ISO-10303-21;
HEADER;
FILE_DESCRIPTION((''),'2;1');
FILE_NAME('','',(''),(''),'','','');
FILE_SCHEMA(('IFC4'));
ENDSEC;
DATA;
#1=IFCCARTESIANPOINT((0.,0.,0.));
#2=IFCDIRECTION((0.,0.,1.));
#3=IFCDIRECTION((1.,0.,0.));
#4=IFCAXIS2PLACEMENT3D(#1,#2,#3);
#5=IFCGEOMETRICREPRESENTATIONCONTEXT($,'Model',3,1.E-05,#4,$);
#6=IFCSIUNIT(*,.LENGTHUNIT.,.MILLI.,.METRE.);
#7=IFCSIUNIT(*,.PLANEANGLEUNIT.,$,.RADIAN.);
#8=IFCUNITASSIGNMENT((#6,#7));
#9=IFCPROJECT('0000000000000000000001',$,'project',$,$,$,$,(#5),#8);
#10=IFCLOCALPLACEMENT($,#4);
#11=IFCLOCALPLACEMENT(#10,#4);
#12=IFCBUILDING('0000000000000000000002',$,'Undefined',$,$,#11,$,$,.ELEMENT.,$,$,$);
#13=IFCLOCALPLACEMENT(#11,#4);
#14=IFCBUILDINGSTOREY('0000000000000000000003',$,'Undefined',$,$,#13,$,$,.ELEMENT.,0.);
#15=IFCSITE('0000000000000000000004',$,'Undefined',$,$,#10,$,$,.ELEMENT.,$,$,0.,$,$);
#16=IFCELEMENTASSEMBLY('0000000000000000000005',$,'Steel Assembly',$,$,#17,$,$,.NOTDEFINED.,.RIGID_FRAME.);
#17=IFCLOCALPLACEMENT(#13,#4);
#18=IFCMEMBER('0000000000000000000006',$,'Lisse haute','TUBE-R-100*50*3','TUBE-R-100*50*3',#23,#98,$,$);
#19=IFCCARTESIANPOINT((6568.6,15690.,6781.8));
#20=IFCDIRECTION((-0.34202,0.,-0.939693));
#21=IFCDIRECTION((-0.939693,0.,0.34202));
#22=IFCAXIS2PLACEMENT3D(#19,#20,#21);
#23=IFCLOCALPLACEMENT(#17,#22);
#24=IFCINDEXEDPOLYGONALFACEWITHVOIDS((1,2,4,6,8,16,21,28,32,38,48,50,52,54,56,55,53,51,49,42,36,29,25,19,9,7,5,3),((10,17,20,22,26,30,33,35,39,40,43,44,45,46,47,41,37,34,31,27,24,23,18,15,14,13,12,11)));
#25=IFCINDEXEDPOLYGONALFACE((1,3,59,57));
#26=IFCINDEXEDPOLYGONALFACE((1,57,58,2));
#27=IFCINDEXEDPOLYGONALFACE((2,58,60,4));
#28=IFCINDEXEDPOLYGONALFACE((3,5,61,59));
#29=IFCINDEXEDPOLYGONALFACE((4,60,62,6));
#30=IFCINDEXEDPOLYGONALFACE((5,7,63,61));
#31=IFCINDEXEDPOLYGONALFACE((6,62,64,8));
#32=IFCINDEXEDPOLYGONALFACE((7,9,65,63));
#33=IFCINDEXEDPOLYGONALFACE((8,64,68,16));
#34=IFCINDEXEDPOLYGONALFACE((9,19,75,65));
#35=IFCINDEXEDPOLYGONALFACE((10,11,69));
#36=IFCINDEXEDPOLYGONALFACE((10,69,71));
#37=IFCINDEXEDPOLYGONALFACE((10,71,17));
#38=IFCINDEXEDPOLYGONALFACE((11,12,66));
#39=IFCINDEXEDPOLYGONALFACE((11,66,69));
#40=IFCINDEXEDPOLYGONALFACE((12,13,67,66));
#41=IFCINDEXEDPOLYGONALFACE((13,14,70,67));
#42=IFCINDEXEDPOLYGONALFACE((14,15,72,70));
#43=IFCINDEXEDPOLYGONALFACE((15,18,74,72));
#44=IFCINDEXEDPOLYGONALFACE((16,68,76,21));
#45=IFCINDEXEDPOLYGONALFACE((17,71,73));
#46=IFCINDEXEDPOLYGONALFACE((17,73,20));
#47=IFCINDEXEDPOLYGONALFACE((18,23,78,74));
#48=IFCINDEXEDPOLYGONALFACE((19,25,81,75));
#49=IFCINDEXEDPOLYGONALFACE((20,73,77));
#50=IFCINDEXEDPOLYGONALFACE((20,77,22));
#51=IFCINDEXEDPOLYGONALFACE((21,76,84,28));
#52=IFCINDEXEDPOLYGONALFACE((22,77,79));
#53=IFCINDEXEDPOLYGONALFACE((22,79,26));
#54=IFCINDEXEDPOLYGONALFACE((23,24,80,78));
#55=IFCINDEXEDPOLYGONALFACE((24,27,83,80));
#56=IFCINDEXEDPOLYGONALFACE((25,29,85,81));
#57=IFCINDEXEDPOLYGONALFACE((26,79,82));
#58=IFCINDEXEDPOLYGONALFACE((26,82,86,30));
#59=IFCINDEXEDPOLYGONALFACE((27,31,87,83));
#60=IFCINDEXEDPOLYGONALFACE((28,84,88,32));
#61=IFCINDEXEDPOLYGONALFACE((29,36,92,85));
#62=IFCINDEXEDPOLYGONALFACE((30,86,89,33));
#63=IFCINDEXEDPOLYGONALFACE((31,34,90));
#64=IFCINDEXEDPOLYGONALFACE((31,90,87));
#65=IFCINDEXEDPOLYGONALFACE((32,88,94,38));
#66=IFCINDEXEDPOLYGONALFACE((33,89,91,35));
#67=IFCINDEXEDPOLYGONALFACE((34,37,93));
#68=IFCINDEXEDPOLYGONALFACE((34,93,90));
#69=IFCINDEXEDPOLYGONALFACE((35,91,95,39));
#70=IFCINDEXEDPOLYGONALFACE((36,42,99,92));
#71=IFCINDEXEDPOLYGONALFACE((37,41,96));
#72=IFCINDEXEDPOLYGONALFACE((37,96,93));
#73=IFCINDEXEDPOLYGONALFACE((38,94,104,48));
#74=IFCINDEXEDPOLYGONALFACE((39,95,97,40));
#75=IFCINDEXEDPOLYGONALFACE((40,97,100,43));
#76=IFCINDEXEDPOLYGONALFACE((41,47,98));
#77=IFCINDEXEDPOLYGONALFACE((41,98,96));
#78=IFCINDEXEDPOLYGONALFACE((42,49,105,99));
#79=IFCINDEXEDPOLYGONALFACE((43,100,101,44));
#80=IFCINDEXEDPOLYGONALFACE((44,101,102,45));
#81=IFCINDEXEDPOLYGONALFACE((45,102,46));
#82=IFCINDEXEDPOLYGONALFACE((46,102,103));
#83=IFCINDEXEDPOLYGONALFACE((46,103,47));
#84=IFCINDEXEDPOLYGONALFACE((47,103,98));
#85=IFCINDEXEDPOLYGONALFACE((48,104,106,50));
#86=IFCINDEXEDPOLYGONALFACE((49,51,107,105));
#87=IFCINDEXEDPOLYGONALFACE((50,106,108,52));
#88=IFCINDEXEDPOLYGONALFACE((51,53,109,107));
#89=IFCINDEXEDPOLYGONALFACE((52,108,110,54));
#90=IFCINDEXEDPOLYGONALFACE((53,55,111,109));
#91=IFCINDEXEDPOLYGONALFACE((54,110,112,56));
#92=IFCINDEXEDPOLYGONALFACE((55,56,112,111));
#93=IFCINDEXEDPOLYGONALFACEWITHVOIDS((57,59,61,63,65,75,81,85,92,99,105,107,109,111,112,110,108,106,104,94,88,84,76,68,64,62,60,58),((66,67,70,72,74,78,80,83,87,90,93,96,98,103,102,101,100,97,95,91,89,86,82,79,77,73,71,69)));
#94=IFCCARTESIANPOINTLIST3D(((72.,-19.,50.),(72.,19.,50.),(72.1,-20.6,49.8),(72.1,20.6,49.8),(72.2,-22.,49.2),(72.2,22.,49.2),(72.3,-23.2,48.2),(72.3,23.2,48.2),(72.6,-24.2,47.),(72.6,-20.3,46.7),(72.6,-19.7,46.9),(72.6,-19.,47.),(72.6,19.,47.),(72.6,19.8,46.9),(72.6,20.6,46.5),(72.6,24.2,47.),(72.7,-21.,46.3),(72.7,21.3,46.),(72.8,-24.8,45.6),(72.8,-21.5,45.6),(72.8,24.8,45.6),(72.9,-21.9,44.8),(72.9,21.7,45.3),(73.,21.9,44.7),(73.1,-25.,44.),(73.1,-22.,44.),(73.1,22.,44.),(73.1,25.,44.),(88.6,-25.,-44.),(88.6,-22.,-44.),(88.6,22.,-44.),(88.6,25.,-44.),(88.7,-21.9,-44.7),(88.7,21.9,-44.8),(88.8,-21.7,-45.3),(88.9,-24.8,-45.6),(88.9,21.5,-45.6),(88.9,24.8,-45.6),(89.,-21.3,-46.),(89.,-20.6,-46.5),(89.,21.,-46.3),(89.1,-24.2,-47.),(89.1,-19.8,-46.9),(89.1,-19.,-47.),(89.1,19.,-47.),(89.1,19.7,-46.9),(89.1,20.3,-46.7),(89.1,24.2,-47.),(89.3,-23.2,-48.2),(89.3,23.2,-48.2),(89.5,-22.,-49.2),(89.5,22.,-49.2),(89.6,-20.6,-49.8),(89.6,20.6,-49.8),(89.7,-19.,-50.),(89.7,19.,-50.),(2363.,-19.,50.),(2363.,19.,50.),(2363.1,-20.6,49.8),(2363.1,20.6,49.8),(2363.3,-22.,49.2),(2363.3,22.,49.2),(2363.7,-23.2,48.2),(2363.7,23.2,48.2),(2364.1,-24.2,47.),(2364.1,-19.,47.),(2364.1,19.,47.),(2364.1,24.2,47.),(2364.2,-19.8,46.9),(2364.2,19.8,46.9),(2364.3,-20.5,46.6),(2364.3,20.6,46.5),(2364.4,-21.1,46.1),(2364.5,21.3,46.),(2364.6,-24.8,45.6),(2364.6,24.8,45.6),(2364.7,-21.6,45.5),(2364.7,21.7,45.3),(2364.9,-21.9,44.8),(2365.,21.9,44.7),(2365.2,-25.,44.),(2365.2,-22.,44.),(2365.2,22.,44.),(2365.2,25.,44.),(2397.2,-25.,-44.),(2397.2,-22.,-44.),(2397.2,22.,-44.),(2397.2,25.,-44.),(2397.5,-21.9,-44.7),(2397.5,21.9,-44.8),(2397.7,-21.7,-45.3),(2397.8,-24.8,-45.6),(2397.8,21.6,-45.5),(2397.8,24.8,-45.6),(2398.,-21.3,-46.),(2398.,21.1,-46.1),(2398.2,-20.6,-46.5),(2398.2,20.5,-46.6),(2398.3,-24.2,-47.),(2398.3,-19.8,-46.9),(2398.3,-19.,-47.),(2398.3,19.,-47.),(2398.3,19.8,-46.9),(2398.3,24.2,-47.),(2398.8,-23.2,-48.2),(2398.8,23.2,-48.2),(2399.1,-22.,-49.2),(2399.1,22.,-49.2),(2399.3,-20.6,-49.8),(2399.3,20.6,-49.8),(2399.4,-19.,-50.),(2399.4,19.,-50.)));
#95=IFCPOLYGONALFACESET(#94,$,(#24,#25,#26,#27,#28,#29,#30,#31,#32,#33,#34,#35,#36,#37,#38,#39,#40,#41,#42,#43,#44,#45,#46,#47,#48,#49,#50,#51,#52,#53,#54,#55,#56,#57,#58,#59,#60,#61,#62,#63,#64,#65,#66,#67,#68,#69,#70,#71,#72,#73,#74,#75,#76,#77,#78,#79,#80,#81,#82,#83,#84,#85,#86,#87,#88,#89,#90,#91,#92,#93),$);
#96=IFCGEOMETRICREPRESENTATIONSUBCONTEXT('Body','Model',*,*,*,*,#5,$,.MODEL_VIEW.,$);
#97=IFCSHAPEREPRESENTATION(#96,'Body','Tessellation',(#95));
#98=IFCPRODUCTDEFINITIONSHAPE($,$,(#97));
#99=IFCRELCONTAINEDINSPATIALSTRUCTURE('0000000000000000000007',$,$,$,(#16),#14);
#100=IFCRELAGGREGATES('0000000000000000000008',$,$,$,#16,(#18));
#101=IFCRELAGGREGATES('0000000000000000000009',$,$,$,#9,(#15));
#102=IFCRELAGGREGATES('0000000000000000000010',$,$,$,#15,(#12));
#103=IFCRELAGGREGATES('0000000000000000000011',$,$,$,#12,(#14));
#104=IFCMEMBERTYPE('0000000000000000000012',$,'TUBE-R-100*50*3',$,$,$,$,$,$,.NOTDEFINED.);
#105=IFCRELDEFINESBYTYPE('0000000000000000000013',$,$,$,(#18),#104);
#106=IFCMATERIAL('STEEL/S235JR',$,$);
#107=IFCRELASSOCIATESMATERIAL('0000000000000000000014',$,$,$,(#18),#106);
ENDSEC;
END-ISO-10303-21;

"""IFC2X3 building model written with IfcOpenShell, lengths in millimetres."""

from ifc_helpers import new_model, si_unit, frame, origin_with_axes, origin_2d_with_axis, place, context, subcontext, project, spatial, hollow_rectangle, extrude, clip, halfspace, material, type_object, element, aggregate, save


model = new_model("IFC2X3")

# Units and contexts
model_context = context("Model", 3, precision=1e-05, world=origin_with_axes())
body_context = subcontext(model_context, "Body", "Model", "MODEL_VIEW")
ifc_project = project(units=[si_unit("LENGTHUNIT", "METRE", prefix="MILLI"), si_unit("PLANEANGLEUNIT", "RADIAN")], contexts=[model_context])

# Site, building, storey
site_placement = place(None, origin_with_axes())
site = spatial("IfcSite", under=ifc_project, at=site_placement, Name="Undefined", CompositionType="ELEMENT", RefElevation=0.0)
building_placement = place(site_placement, origin_with_axes())
building = spatial("IfcBuilding", under=site, at=building_placement, Name="Undefined", CompositionType="ELEMENT")
storey_placement = place(building_placement, origin_with_axes())
storey = spatial("IfcBuildingStorey", under=building, at=storey_placement, Name="Undefined", CompositionType="ELEMENT", Elevation=0.0)

# Shared definitions
ifc_material_1 = material(Name="STEEL/S235JR")

# Element assembly, member
assembly_1_placement = place(storey_placement, origin_with_axes())
assembly_1 = element("IfcElementAssembly", 1, at=assembly_1_placement, inside=storey, Name="Steel Assembly", AssemblyPlace="NOTDEFINED", PredefinedType="RIGID_FRAME")
member_type = type_object("IfcMemberType", Name="TUBE-R-100*50*3", PredefinedType="NOTDEFINED")
member_placement = place(assembly_1_placement, frame((6568.6, 15690.0, 6781.8), z_axis=(-0.34202, 0.0, -0.939693), x_axis=(-0.939693, 0.0, 0.34202)))
member = element("IfcMember", 2, at=member_placement, type_object=member_type, material=ifc_material_1, Name="Lisse haute", Description="TUBE-R-100*50*3", ObjectType="TUBE-R-100*50*3", context=body_context, shape_type="Clipping", body=[
    clip(clip(extrude(hollow_rectangle(XDim=50.0, YDim=100.0, WallThickness=3.0, InnerFilletRadius=3.0, OuterFilletRadius=6.0, at=origin_2d_with_axis()), frame((2425.2, 0.0, 0.0), z_axis=(-1.0, 0.0, 0.0), x_axis=(0.0, -1.0, 0.0)), (0.0, 0.0, 1.0), 2388.4), halfspace(frame((2363.0, 0.0, 50.0), z_axis=(-0.939693, 0.0, -0.34202), x_axis=(0.0, -1.0, 0.0)), True)), halfspace(frame((72.0, -22.0, 50.0), z_axis=(-0.984808, 0.0, -0.173648), x_axis=(0.0, -1.0, 0.0)), False)),
])

aggregate(assembly_1, [member])

save(model, "model.ifc")
